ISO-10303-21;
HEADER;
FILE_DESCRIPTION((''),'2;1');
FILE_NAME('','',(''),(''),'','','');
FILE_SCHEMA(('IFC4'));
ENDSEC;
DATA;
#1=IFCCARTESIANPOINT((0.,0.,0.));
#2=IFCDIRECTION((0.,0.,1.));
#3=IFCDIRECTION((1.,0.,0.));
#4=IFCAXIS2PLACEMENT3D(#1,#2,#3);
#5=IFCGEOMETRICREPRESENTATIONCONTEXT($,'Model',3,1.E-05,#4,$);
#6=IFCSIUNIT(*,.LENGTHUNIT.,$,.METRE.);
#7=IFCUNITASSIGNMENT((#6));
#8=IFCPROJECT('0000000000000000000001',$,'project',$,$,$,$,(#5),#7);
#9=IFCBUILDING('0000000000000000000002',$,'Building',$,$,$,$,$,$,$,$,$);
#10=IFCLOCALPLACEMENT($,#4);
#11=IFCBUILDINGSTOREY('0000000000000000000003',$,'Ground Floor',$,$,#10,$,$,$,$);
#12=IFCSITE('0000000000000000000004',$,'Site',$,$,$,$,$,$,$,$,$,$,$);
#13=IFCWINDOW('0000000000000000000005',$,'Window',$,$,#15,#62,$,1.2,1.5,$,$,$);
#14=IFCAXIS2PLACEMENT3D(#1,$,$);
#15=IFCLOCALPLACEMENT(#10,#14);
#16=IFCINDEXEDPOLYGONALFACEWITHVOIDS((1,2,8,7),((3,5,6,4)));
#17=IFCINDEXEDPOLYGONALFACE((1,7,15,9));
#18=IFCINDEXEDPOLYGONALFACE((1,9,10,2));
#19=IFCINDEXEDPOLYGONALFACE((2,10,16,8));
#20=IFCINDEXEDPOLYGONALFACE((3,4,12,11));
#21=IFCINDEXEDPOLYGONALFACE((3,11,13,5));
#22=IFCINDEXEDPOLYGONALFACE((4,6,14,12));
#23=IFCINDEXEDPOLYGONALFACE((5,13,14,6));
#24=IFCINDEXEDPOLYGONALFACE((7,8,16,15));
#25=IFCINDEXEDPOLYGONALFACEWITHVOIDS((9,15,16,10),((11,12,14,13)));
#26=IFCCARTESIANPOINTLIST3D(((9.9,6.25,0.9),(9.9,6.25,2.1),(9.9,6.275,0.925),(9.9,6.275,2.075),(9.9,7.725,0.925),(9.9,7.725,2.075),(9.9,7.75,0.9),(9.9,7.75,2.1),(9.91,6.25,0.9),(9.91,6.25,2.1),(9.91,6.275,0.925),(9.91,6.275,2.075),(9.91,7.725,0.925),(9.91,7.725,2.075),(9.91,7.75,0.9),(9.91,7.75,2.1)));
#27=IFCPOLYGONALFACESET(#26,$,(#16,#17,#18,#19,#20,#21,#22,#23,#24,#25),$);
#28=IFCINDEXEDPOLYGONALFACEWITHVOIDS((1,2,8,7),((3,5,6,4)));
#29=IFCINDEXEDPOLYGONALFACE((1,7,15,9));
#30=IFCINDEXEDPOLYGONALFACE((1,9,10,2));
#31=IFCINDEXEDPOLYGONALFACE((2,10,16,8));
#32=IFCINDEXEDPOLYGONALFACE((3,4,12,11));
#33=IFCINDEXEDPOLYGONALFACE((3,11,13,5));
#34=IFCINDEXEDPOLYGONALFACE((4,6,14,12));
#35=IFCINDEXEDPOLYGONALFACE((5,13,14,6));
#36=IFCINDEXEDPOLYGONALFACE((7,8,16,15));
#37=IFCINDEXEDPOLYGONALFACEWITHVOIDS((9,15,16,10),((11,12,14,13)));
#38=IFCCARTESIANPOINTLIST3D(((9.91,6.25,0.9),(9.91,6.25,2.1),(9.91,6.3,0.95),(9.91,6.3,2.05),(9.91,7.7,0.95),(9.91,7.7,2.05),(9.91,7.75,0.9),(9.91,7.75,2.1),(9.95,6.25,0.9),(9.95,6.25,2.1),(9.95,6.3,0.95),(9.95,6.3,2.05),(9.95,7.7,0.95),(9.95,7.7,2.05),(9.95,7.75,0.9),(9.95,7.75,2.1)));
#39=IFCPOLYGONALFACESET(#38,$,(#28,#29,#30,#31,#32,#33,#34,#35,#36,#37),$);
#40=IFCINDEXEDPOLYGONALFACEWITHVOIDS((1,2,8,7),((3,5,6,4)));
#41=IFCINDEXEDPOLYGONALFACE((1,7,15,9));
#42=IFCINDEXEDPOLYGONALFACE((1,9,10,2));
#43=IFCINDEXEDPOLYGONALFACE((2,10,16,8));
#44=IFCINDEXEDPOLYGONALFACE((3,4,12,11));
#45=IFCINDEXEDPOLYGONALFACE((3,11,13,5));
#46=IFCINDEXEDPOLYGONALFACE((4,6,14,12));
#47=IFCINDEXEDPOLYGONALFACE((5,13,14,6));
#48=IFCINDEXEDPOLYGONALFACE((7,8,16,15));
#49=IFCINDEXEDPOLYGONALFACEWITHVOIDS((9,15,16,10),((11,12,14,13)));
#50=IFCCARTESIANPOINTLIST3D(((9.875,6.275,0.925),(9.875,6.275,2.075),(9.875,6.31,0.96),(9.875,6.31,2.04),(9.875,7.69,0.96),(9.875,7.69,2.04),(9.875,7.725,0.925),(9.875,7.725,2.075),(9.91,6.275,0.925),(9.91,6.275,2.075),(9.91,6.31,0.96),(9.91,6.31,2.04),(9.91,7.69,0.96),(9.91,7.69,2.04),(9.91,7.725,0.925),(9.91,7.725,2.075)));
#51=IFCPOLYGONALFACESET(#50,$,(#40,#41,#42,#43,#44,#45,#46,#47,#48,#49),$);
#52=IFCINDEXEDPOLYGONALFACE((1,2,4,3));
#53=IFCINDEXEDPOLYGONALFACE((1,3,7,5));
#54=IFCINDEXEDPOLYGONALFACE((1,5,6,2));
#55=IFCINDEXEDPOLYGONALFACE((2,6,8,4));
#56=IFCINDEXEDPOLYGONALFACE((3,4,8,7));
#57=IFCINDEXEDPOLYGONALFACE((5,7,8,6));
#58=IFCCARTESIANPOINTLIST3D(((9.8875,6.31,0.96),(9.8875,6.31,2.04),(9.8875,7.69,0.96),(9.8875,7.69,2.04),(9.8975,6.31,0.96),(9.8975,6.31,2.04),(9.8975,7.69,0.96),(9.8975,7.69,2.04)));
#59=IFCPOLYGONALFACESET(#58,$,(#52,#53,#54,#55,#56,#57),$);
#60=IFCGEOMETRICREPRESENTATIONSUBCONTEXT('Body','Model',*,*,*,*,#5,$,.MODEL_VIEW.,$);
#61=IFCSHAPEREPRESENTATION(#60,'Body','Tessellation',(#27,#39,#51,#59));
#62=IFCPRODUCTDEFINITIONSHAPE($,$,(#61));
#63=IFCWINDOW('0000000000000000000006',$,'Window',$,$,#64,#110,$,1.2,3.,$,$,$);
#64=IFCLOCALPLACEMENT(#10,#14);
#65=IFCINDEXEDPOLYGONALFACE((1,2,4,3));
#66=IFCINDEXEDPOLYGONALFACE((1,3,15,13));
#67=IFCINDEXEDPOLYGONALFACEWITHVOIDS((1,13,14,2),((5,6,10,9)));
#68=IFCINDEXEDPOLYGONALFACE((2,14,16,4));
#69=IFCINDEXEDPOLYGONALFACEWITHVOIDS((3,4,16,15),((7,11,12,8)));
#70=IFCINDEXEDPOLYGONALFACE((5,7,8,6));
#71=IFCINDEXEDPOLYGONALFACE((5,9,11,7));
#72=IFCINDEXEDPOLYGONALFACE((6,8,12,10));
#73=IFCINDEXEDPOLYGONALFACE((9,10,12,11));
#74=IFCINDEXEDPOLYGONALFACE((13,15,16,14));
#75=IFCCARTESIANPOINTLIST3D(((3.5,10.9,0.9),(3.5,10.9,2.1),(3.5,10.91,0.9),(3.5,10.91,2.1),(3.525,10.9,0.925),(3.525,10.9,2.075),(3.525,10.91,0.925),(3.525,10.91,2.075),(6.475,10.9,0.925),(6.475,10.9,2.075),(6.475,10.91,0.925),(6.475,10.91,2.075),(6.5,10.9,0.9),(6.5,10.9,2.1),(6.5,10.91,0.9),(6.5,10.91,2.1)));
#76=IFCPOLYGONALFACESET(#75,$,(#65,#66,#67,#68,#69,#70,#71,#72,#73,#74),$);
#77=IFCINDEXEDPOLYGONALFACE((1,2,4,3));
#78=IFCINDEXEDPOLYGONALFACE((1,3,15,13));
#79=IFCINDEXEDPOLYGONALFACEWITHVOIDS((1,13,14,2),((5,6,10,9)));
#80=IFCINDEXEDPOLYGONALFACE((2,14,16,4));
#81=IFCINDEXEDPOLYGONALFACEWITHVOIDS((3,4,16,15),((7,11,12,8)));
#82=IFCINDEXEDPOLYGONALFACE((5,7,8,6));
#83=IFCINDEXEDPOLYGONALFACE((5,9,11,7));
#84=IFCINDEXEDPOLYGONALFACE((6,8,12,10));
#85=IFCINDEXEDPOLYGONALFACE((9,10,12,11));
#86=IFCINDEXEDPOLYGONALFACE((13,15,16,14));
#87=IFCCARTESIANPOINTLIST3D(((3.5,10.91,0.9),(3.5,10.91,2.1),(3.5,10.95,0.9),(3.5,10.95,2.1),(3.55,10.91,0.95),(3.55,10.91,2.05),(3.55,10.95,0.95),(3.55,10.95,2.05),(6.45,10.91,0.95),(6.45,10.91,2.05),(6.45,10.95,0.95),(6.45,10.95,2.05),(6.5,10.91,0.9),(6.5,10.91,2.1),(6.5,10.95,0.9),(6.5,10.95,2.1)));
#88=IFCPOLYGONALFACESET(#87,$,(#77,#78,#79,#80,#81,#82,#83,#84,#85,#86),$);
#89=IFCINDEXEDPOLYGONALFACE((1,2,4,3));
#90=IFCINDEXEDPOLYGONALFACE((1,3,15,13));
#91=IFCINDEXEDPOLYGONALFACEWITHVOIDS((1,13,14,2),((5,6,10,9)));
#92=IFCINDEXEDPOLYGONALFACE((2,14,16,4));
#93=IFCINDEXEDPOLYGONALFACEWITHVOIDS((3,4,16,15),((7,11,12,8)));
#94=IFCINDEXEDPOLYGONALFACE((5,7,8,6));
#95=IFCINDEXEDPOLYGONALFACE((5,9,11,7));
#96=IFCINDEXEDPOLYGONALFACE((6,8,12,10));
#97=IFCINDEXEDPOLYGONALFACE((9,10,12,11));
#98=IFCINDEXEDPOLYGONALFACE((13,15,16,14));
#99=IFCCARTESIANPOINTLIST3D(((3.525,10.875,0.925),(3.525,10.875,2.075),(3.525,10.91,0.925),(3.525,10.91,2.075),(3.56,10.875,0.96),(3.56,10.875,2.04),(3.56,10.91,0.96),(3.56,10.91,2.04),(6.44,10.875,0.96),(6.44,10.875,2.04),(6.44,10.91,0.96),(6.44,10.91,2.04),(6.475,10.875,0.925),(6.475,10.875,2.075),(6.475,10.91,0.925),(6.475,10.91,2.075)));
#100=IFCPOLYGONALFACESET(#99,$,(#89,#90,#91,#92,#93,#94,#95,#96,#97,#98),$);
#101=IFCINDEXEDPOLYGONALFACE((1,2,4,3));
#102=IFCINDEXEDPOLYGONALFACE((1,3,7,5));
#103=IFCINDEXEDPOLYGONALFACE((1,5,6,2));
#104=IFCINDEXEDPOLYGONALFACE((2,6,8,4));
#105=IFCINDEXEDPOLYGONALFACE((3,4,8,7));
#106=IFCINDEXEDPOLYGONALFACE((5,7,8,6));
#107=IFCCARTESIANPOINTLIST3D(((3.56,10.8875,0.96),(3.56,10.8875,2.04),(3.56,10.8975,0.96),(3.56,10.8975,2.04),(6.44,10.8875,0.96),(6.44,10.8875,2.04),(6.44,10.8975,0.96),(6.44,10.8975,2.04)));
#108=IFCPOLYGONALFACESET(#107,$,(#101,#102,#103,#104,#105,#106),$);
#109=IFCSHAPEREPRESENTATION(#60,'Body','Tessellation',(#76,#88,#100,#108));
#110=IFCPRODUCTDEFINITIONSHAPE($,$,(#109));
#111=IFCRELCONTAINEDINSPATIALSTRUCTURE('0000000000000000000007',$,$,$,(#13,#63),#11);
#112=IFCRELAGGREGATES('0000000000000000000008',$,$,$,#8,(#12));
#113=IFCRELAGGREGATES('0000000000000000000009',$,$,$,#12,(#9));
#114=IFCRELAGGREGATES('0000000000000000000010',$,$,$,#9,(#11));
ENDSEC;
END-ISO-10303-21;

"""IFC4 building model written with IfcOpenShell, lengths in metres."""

from ifc_helpers import new_model, si_unit, frame, origin_with_axes, place, context, subcontext, project, spatial, line, indexed_curve, outline, extrude, element, save


model = new_model("IFC4")

# Units and contexts
model_context = context("Model", 3, precision=1e-05, world=origin_with_axes())
body_context = subcontext(model_context, "Body", "Model", "MODEL_VIEW")
ifc_project = project(units=[si_unit("LENGTHUNIT", "METRE")], contexts=[model_context])

# Site, building, storey
site = spatial("IfcSite", under=ifc_project, Name="Site")
building = spatial("IfcBuilding", under=site, Name="Building")
storey_placement = place(None, origin_with_axes())
storey = spatial("IfcBuildingStorey", under=building, at=storey_placement, Name="Ground Floor")

# Windows
window_1_placement = place(storey_placement, frame((10.0, 6.25, 0.9), z_axis=(0.0, 0.0, 1.0), x_axis=(0.0, 1.0, 0.0)))
element("IfcWindow", 1, at=window_1_placement, inside=storey, Name="Window", OverallHeight=1.2, OverallWidth=1.5, context=body_context, shape_type="SweptSolid", body=[
    extrude(outline(indexed_curve([(0.0, 0.0), (1.5, 0.0), (1.5, 1.2), (0.0, 1.2)], segments=[line(1, 2, 3, 4, 1)]), holes=[indexed_curve([(0.025, 0.025), (1.475, 0.025), (1.475, 1.175), (0.025, 1.175)], segments=[line(1, 2, 3, 4, 1)])]), frame((0.0, 0.09, 0.0), z_axis=(0.0, -1.0, 0.0), x_axis=(1.0, 0.0, 0.0)), (0.0, 0.0, -1.0), 0.01),
    extrude(outline(indexed_curve([(0.0, 0.0), (1.5, 0.0), (1.5, 1.2), (0.0, 1.2)], segments=[line(1, 2, 3, 4, 1)]), holes=[indexed_curve([(0.05, 0.05), (1.45, 0.05), (1.45, 1.15), (0.05, 1.15)], segments=[line(1, 2, 3, 4, 1)])]), frame((0.0, 0.05, 0.0), z_axis=(0.0, -1.0, 0.0), x_axis=(1.0, 0.0, 0.0)), (0.0, 0.0, -1.0), 0.04),
    extrude(outline(indexed_curve([(0.0, 0.0), (1.45, 0.0), (1.45, 1.15), (0.0, 1.15)], segments=[line(1, 2, 3, 4, 1)]), holes=[indexed_curve([(0.035, 0.035), (1.415, 0.035), (1.415, 1.115), (0.035, 1.115)], segments=[line(1, 2, 3, 4, 1)])]), frame((0.025, 0.09, 0.025), z_axis=(0.0, -1.0, 0.0), x_axis=(1.0, 0.0, 0.0)), (0.0, 0.0, -1.0), 0.035),
    extrude(outline(indexed_curve([(0.035, 0.035), (1.415, 0.035), (1.415, 1.115), (0.035, 1.115)], segments=[line(1, 2, 3, 4, 1)])), frame((0.025, 0.1025, 0.025), z_axis=(0.0, -1.0, 0.0), x_axis=(1.0, 0.0, 0.0)), (0.0, 0.0, -1.0), 0.01),
])
window_2_placement = place(storey_placement, frame((6.5, 11.0, 0.9), z_axis=(0.0, 0.0, 1.0), x_axis=(-1.0, 0.0, 0.0)))
element("IfcWindow", 2, at=window_2_placement, inside=storey, Name="Window", OverallHeight=1.2, OverallWidth=3.0, context=body_context, shape_type="SweptSolid", body=[
    extrude(outline(indexed_curve([(0.0, 0.0), (3.0, 0.0), (3.0, 1.2), (0.0, 1.2)], segments=[line(1, 2, 3, 4, 1)]), holes=[indexed_curve([(0.025, 0.025), (2.975, 0.025), (2.975, 1.175), (0.025, 1.175)], segments=[line(1, 2, 3, 4, 1)])]), frame((0.0, 0.09, 0.0), z_axis=(0.0, -1.0, 0.0), x_axis=(1.0, 0.0, 0.0)), (0.0, 0.0, -1.0), 0.01),
    extrude(outline(indexed_curve([(0.0, 0.0), (3.0, 0.0), (3.0, 1.2), (0.0, 1.2)], segments=[line(1, 2, 3, 4, 1)]), holes=[indexed_curve([(0.05, 0.05), (2.95, 0.05), (2.95, 1.15), (0.05, 1.15)], segments=[line(1, 2, 3, 4, 1)])]), frame((0.0, 0.05, 0.0), z_axis=(0.0, -1.0, 0.0), x_axis=(1.0, 0.0, 0.0)), (0.0, 0.0, -1.0), 0.04),
    extrude(outline(indexed_curve([(0.0, 0.0), (2.95, 0.0), (2.95, 1.15), (0.0, 1.15)], segments=[line(1, 2, 3, 4, 1)]), holes=[indexed_curve([(0.035, 0.035), (2.915, 0.035), (2.915, 1.115), (0.035, 1.115)], segments=[line(1, 2, 3, 4, 1)])]), frame((0.025, 0.09, 0.025), z_axis=(0.0, -1.0, 0.0), x_axis=(1.0, 0.0, 0.0)), (0.0, 0.0, -1.0), 0.035),
    extrude(outline(indexed_curve([(0.035, 0.035), (2.915, 0.035), (2.915, 1.115), (0.035, 1.115)], segments=[line(1, 2, 3, 4, 1)])), frame((0.025, 0.1025, 0.025), z_axis=(0.0, -1.0, 0.0), x_axis=(1.0, 0.0, 0.0)), (0.0, 0.0, -1.0), 0.01),
])

save(model, "model.ifc")
